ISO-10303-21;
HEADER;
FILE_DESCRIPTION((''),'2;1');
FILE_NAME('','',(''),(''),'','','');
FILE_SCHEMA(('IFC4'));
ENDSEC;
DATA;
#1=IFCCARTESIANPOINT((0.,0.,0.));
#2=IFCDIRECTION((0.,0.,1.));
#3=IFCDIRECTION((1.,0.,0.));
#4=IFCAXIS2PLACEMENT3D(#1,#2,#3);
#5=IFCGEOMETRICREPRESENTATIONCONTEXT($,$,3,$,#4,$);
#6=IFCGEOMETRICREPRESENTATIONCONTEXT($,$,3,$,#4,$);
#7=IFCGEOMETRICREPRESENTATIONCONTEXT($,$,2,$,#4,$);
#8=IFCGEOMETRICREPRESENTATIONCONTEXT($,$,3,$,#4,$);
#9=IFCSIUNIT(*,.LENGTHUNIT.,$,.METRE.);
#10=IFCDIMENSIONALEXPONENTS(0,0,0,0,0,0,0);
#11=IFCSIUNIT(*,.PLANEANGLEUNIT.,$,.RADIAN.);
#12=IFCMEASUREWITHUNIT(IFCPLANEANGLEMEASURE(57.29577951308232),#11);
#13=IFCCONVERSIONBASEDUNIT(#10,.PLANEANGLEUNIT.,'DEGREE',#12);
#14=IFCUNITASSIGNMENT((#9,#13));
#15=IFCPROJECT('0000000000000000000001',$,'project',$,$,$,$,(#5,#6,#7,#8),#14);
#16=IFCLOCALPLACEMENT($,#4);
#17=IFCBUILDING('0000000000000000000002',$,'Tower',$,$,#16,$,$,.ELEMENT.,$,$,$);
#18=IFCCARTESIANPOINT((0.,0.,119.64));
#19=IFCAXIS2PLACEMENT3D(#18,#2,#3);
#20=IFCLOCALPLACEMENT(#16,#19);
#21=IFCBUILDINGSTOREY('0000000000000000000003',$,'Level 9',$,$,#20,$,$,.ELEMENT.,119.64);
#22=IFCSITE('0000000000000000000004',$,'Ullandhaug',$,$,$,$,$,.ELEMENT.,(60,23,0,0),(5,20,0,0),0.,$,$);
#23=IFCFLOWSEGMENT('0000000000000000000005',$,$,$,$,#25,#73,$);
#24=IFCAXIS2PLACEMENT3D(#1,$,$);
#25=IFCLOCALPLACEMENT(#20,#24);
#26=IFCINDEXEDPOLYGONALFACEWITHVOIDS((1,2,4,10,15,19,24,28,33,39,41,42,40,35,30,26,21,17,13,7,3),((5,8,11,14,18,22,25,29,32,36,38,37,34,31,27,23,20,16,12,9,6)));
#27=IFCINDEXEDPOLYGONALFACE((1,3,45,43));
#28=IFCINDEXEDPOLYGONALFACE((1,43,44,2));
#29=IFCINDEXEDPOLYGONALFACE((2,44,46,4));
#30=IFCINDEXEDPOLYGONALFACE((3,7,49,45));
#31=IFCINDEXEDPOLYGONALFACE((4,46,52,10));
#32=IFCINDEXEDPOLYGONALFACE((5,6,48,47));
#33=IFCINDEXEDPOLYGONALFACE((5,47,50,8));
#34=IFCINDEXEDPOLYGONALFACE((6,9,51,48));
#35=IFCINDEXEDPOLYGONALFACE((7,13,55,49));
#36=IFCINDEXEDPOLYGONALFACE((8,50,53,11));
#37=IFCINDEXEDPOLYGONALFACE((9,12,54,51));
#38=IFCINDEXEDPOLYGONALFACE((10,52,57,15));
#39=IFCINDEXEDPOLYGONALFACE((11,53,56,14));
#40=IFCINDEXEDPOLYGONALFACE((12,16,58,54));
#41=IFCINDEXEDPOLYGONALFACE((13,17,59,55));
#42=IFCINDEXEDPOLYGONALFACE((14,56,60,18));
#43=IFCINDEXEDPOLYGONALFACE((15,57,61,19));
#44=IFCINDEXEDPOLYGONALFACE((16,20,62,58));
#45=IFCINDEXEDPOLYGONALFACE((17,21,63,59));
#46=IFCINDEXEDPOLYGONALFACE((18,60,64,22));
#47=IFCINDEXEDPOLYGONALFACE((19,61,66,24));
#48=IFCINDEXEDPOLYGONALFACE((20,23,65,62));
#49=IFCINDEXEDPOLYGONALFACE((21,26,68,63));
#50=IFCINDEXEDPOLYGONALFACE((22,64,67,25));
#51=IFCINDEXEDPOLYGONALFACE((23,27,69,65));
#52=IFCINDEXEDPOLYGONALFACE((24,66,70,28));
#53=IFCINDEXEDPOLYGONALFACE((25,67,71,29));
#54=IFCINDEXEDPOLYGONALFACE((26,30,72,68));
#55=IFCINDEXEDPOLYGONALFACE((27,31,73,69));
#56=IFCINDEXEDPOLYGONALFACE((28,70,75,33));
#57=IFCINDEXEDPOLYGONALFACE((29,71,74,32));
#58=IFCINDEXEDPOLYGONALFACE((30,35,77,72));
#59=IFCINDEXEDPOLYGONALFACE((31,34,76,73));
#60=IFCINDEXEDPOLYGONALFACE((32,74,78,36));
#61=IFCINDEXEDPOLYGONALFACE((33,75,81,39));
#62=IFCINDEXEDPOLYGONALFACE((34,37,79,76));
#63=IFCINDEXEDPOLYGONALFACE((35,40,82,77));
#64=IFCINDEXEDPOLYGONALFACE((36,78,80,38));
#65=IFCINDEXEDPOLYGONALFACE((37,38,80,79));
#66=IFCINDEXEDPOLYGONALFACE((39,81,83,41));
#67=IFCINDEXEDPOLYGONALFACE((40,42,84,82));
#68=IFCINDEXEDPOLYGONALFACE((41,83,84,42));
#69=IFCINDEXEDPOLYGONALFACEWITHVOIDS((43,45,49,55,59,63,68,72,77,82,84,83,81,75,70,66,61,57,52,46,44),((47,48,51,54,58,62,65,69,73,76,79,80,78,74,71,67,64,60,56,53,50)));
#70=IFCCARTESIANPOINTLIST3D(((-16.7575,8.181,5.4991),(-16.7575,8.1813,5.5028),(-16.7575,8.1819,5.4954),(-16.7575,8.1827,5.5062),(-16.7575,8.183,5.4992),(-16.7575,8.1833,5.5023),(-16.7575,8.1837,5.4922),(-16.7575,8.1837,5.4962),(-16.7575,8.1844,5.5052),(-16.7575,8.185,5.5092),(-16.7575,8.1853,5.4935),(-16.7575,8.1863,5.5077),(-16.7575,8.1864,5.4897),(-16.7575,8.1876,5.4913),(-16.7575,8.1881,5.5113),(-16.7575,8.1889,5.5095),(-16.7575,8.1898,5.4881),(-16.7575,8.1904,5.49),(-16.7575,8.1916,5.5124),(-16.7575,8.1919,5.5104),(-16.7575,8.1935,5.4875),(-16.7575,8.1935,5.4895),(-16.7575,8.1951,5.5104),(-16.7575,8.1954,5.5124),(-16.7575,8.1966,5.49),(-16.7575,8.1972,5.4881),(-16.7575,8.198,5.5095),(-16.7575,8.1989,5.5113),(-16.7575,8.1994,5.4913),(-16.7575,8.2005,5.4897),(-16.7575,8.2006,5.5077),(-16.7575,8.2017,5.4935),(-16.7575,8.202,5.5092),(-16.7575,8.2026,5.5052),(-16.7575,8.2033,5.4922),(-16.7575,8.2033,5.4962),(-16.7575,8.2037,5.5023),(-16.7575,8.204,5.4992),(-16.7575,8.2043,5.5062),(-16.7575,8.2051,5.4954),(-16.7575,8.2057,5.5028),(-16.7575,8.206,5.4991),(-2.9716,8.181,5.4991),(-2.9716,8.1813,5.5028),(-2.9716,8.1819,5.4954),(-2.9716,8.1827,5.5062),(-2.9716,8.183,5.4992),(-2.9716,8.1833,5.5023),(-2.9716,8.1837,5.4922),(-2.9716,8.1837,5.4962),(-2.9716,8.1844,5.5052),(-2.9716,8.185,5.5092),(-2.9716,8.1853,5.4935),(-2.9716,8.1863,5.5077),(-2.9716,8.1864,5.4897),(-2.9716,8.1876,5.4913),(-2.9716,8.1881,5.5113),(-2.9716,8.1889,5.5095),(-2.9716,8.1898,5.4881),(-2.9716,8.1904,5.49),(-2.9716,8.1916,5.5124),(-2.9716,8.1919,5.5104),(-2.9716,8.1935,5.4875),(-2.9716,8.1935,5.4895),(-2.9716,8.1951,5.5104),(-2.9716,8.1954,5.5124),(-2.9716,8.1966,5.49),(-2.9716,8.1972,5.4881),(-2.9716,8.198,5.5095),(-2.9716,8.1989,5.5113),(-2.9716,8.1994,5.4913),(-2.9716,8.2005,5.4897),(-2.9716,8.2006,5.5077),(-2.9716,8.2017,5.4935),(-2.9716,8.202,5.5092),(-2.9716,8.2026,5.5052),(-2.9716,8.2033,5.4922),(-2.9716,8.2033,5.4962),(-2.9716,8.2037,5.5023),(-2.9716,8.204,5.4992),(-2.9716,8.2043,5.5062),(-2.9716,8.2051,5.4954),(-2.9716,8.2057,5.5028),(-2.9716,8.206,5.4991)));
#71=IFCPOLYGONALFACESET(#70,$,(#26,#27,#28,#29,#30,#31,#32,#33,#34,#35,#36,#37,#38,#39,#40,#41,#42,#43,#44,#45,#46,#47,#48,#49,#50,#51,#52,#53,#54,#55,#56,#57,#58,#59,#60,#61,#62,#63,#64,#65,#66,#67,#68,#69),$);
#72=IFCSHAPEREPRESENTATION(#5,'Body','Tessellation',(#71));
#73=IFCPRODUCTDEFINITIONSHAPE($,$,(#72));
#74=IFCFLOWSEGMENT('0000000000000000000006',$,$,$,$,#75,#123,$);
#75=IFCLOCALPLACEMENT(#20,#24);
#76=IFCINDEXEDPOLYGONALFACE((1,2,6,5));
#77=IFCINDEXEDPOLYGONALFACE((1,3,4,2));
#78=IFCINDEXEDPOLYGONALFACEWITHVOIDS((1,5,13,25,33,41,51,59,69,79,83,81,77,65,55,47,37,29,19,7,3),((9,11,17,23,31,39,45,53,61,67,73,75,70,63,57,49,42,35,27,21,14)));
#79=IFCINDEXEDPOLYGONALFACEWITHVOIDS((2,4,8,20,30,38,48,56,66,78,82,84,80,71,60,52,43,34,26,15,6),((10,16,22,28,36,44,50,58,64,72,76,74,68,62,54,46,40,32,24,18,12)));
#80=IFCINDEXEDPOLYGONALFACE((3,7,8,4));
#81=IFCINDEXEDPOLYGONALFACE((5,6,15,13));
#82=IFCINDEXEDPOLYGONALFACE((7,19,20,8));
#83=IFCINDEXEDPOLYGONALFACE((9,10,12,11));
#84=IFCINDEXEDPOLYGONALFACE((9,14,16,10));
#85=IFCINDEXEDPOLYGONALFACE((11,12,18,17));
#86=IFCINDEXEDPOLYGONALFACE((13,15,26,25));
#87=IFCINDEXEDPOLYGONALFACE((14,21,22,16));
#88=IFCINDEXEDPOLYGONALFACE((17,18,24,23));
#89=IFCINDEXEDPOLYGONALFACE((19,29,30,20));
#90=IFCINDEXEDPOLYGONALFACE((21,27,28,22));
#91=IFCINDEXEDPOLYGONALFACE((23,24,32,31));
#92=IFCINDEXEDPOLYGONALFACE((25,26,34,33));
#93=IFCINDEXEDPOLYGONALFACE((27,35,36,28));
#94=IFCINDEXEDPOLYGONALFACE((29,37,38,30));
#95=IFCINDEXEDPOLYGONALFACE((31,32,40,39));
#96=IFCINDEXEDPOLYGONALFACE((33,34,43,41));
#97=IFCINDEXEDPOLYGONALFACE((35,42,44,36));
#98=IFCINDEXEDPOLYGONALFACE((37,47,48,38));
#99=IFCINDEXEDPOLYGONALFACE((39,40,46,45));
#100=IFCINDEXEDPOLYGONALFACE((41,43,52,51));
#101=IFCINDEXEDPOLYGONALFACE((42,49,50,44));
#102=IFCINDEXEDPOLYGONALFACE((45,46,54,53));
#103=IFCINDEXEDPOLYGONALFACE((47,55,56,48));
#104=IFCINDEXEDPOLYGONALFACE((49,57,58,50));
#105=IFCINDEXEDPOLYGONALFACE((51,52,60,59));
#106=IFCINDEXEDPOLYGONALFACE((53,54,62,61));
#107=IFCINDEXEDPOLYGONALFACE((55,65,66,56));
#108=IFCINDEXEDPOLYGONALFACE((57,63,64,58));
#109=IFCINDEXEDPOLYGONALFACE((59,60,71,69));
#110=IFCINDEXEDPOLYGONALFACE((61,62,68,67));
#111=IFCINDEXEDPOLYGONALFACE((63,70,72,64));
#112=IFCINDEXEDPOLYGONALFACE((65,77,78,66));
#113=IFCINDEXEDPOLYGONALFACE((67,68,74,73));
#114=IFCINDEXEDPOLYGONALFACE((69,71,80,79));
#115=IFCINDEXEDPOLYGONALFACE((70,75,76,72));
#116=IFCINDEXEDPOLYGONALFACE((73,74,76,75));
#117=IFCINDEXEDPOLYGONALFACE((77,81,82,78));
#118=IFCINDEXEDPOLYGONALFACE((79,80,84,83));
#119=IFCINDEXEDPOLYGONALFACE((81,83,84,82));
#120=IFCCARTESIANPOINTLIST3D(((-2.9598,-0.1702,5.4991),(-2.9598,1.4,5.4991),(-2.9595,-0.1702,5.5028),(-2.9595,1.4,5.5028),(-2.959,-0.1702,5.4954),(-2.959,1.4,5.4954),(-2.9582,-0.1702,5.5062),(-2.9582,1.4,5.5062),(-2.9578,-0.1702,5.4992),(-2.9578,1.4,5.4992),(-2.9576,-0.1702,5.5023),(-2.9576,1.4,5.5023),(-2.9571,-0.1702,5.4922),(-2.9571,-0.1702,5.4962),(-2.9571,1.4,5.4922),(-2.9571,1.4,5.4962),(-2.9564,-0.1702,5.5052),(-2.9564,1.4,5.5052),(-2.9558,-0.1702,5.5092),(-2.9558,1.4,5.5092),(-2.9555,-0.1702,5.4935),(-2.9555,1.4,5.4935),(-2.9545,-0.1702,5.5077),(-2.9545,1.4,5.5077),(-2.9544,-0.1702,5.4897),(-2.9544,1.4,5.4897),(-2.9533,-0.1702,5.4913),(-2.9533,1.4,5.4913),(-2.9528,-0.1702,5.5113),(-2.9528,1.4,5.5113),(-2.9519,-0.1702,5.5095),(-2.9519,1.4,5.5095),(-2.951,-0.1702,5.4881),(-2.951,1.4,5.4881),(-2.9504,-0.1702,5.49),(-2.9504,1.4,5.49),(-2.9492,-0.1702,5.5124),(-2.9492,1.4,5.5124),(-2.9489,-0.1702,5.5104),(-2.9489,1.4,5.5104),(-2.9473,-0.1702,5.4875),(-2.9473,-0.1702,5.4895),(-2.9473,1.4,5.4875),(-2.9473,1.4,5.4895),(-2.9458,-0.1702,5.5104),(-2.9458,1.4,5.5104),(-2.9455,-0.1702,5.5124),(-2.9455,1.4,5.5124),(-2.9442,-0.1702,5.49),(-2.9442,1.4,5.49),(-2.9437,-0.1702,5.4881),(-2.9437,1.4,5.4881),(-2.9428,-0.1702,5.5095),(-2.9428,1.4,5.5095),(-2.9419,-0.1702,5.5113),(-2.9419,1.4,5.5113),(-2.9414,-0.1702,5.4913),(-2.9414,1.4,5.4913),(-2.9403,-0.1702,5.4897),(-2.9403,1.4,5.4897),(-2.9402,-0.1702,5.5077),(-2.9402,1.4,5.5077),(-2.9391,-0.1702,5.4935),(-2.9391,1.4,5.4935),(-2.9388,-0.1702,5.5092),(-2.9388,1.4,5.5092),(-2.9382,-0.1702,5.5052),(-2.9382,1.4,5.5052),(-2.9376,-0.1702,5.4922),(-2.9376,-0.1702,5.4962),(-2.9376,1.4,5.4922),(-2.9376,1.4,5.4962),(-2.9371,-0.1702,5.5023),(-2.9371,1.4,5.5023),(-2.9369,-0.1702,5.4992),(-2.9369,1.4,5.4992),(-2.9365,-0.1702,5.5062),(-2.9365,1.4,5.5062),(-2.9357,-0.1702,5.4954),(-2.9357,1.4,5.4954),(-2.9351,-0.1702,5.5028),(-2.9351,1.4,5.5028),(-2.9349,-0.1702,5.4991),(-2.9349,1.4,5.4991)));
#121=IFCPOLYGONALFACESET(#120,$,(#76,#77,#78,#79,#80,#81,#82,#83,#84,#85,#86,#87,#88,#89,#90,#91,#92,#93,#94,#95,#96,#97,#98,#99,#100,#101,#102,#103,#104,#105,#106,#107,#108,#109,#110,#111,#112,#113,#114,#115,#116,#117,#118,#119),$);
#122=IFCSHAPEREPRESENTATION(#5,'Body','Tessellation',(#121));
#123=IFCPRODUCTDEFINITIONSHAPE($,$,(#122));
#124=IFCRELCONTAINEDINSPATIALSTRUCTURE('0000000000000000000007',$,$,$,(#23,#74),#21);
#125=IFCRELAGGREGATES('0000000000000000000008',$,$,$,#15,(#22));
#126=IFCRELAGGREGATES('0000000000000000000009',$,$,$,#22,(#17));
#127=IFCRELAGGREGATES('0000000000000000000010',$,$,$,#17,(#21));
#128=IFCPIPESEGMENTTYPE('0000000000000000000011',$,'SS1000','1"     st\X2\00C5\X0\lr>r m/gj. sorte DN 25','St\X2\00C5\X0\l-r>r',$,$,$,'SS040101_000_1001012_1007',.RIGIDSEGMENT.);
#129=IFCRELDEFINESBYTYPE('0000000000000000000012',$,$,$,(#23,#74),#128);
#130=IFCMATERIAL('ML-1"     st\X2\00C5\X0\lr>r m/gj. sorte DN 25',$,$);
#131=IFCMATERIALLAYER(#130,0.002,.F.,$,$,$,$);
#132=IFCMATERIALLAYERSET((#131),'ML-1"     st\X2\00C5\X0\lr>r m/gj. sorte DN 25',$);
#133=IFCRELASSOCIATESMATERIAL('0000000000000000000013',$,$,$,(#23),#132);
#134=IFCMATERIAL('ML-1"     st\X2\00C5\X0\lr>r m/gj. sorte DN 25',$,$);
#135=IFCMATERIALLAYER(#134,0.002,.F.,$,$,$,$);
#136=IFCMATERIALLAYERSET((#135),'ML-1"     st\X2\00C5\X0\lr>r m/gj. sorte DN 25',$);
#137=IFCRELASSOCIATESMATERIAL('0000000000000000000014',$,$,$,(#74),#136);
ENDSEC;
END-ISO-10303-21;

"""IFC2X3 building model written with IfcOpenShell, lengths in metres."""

from ifc_helpers import new_model, entity, si_unit, converted_unit, frame, origin_with_axes, origin_2d_with_axis, place, context, project, spatial, hollow_circle, extrude, material, layer, layer_set, layer_usage, type_object, element, save


model = new_model("IFC2X3")

# Units and contexts
context_of_model_1 = context(None, 3, world=origin_with_axes())
context_of_model_2 = context(None, 3, world=origin_with_axes())
context_of_model_3 = context(None, 2, world=origin_with_axes())
context_of_model_4 = context(None, 3, world=origin_with_axes())
ifc_project = project(units=[si_unit("LENGTHUNIT", "METRE"), converted_unit("PLANEANGLEUNIT", "DEGREE", entity("IfcPlaneAngleMeasure", 57.29577951308232), si_unit("PLANEANGLEUNIT", "RADIAN"), dimensions=[0, 0, 0, 0, 0, 0, 0])], contexts=[context_of_model_1, context_of_model_2, context_of_model_3, context_of_model_4])

# Site, building, storey
site = spatial("IfcSite", under=ifc_project, Name="Ullandhaug", CompositionType="ELEMENT", RefLatitude=(60, 23, 0, 0), RefLongitude=(5, 20, 0, 0), RefElevation=0.0)
building_placement = place(None, origin_with_axes())
building = spatial("IfcBuilding", under=site, at=building_placement, Name="Tower", CompositionType="ELEMENT")
storey_placement = place(building_placement, frame((0.0, 0.0, 119.64), z_axis=(0.0, 0.0, 1.0), x_axis=(1.0, 0.0, 0.0)))
storey = spatial("IfcBuildingStorey", under=building, at=storey_placement, Name="Level 9", CompositionType="ELEMENT", Elevation=119.64)

# Flow segments
pipe_segment_type_1 = type_object("IfcPipeSegmentType", Name="SS1000", Description="1\"     stÅlr>r m/gj. sorte DN 25", ApplicableOccurrence="StÅl-r>r", ElementType="SS040101_000_1001012_1007", PredefinedType="RIGIDSEGMENT")
ifc_material_1 = material(Name="ML-1\"     stÅlr>r m/gj. sorte DN 25")
ifc_layer_1 = layer(ifc_material_1, 0.002, ventilated=False)
ifc_layer_set_1 = layer_set([ifc_layer_1], Name="ML-1\"     stÅlr>r m/gj. sorte DN 25")
ifc_layer_usage_1 = layer_usage(ifc_layer_set_1, "AXIS2", "POSITIVE", 0.0)
flow_segment_1_placement = place(storey_placement, frame((-2.9716, 8.1935, 5.5), z_axis=(-1.0, 0.0, 0.0), x_axis=(0.0, 0.0, -1.0)))
element("IfcFlowSegment", 1, at=flow_segment_1_placement, inside=storey, type_object=pipe_segment_type_1, material=ifc_layer_usage_1, context=context_of_model_1, shape_type="SweptSolid", body=[
    extrude(hollow_circle(Radius=0.0125, WallThickness=0.002, at=origin_2d_with_axis()), origin_with_axes(), (0.0, 0.0, 1.0), 13.7859),
])
ifc_material_2 = material(Name="ML-1\"     stÅlr>r m/gj. sorte DN 25")
ifc_layer_2 = layer(ifc_material_2, 0.002, ventilated=False)
ifc_layer_set_2 = layer_set([ifc_layer_2], Name="ML-1\"     stÅlr>r m/gj. sorte DN 25")
ifc_layer_usage_2 = layer_usage(ifc_layer_set_2, "AXIS2", "POSITIVE", 0.0)
flow_segment_2_placement = place(storey_placement, frame((-2.9473, -0.1702, 5.5), z_axis=(0.0, 1.0, 0.0), x_axis=(0.0, 0.0, -1.0)))
element("IfcFlowSegment", 2, at=flow_segment_2_placement, inside=storey, type_object=pipe_segment_type_1, material=ifc_layer_usage_2, context=context_of_model_1, shape_type="SweptSolid", body=[
    extrude(hollow_circle(Radius=0.0125, WallThickness=0.002, at=origin_2d_with_axis()), origin_with_axes(), (0.0, 0.0, 1.0), 1.5702),
])

save(model, "model.ifc")
